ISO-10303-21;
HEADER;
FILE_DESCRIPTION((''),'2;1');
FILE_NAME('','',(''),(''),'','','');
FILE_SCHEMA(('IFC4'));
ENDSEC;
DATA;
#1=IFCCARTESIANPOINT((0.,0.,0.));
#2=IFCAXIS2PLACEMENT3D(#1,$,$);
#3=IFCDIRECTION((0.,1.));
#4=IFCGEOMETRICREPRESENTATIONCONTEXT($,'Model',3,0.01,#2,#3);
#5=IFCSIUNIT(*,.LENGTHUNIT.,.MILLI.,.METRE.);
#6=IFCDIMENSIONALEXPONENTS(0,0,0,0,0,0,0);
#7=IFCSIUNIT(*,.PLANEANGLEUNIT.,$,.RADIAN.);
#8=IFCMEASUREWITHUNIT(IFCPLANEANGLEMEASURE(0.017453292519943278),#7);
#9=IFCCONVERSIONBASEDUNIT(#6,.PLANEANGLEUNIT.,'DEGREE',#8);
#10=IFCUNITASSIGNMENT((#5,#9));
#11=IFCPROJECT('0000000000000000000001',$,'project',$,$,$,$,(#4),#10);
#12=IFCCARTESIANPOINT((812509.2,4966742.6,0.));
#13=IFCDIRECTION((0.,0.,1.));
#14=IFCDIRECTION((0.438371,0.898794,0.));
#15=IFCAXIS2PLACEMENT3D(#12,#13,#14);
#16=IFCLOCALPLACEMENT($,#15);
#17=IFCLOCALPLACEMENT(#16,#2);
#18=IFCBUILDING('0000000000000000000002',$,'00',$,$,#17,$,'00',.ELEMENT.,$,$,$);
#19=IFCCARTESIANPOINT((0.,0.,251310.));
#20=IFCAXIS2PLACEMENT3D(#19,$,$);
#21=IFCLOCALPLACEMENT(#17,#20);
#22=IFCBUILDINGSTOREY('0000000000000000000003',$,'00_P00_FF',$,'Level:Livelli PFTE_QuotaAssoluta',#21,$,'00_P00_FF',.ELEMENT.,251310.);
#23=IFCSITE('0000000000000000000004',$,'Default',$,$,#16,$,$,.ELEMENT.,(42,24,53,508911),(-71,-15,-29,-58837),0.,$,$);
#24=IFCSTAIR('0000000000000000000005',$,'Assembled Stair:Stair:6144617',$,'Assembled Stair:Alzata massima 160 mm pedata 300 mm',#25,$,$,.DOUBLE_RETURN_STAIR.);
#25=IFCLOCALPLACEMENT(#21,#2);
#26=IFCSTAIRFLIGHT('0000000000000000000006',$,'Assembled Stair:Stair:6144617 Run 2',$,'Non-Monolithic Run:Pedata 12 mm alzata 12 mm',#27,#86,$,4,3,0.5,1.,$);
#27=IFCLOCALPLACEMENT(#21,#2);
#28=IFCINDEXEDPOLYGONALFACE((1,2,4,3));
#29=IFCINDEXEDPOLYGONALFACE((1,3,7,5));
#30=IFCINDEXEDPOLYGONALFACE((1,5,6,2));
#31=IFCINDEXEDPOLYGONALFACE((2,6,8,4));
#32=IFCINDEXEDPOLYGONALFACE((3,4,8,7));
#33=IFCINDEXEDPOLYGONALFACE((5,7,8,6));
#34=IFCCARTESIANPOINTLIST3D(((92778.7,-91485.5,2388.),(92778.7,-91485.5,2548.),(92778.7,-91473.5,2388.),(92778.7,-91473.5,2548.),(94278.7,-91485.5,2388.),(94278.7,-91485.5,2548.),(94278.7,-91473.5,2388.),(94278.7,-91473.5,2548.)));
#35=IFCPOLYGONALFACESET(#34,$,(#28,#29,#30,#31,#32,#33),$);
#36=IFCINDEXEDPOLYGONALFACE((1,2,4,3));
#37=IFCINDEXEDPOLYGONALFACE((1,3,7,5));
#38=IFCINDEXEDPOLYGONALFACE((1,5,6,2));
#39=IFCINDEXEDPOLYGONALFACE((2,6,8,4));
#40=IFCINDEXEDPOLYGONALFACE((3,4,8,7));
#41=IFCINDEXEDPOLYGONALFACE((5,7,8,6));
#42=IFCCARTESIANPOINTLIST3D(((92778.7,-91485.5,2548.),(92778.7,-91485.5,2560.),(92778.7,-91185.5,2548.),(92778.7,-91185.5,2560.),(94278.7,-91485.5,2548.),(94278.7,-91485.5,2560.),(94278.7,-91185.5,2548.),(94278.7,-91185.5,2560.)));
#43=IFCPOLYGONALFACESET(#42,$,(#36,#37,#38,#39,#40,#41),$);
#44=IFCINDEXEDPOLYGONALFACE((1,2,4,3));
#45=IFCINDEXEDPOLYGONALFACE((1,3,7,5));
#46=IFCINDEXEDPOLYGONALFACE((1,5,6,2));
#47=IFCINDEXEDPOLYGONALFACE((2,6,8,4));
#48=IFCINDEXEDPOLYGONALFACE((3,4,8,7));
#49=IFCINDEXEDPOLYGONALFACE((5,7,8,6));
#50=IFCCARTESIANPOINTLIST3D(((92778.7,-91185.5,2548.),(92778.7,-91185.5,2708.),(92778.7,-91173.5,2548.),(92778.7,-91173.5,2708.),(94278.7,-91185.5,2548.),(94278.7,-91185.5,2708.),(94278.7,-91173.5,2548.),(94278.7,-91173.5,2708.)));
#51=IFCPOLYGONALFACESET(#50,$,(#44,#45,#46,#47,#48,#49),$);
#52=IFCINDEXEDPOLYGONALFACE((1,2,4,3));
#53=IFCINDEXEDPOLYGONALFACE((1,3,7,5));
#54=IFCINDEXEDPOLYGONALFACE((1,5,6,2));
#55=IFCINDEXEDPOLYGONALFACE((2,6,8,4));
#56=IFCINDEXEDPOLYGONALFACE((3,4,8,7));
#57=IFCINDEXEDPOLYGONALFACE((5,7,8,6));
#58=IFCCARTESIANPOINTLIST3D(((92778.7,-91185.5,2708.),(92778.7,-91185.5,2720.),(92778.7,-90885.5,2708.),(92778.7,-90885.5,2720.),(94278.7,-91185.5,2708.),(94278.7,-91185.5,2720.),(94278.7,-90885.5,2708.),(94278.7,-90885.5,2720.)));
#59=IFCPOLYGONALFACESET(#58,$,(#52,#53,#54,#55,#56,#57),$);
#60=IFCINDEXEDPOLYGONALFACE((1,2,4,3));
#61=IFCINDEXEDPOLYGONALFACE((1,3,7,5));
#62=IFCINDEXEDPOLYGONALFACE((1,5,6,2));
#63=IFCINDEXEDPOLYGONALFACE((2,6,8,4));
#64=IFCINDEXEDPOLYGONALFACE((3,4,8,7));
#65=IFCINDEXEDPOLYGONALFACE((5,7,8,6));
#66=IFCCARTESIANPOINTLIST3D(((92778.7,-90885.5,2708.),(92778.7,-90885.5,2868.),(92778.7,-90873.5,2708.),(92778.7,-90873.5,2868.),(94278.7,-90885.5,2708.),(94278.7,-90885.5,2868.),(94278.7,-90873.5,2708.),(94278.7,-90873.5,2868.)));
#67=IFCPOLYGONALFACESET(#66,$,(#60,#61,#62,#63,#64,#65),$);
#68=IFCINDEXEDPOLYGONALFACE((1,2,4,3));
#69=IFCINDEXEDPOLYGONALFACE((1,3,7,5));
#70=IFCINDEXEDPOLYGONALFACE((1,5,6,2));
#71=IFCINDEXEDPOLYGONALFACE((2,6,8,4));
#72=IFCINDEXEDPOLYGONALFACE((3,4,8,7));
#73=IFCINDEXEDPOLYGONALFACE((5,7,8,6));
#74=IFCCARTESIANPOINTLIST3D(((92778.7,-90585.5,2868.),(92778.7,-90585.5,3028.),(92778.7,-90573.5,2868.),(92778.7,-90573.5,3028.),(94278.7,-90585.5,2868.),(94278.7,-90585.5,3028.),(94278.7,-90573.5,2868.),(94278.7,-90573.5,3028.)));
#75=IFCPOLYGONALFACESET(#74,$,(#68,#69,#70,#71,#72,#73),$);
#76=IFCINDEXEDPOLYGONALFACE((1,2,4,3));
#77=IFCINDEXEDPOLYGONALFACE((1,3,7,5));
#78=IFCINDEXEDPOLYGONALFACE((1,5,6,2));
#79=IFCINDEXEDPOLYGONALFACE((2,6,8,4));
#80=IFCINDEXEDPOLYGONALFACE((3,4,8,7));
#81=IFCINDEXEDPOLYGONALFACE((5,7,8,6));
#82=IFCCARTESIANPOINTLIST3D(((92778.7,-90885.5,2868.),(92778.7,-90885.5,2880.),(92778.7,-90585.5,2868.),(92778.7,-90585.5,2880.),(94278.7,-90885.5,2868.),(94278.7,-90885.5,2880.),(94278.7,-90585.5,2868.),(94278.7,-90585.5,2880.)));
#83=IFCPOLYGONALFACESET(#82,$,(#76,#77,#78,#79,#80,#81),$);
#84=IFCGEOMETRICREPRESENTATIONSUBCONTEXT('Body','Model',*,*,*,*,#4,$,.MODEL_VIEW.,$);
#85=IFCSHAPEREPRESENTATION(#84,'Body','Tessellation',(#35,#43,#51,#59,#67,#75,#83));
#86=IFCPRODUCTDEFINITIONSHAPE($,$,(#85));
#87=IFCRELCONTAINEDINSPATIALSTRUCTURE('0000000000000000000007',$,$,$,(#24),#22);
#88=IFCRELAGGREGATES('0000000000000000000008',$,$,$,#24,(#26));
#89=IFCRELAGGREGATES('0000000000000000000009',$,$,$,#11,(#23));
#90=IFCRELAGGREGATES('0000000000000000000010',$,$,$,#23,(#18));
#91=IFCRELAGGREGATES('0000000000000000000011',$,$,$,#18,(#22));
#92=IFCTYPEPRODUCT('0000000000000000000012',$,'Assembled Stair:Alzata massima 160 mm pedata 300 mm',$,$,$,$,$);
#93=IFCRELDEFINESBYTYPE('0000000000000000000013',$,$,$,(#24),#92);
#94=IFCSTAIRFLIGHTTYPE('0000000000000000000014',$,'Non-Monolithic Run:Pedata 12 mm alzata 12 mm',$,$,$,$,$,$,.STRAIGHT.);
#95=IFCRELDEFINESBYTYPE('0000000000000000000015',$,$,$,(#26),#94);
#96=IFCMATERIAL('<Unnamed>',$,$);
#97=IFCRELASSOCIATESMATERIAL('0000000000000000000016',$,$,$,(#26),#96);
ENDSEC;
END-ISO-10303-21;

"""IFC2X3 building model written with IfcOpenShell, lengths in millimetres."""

from ifc_helpers import new_model, entity, si_unit, converted_unit, direction, frame, frame_2d, origin, origin_2d_with_axis, place, context, subcontext, project, spatial, rectangle, extrude, material, type_object, element, aggregate, save


model = new_model("IFC2X3")

# Units and contexts
model_context = context("Model", 3, precision=0.01, world=origin(), true_north=direction((0.0, 1.0)))
body_context = subcontext(model_context, "Body", "Model", "MODEL_VIEW")
ifc_project = project(units=[si_unit("LENGTHUNIT", "METRE", prefix="MILLI"), converted_unit("PLANEANGLEUNIT", "DEGREE", entity("IfcPlaneAngleMeasure", 0.017453292519943278), si_unit("PLANEANGLEUNIT", "RADIAN"), dimensions=[0, 0, 0, 0, 0, 0, 0])], contexts=[model_context])

# Site, building, storey
site_placement = place(None, frame((812509.2, 4966742.6, 0.0), z_axis=(0.0, 0.0, 1.0), x_axis=(0.438371, 0.898794, 0.0)))
site = spatial("IfcSite", under=ifc_project, at=site_placement, Name="Default", CompositionType="ELEMENT", RefLatitude=(42, 24, 53, 508911), RefLongitude=(-71, -15, -29, -58837), RefElevation=0.0)
building_placement = place(site_placement, origin())
building = spatial("IfcBuilding", under=site, at=building_placement, Name="00", LongName="00", CompositionType="ELEMENT")
storey_placement = place(building_placement, frame((0.0, 0.0, 251310.0)))
storey = spatial("IfcBuildingStorey", under=building, at=storey_placement, Name="00_P00_FF", ObjectType="Level:Livelli PFTE_QuotaAssoluta", LongName="00_P00_FF", CompositionType="ELEMENT", Elevation=251310.0)

# Stair
type_product_1 = type_object("IfcTypeProduct", Name="Assembled Stair:Alzata massima 160 mm pedata 300 mm")
stair_1_placement = place(storey_placement, origin())
stair_1 = element("IfcStair", 1, at=stair_1_placement, inside=storey, type_object=type_product_1, Name="Assembled Stair:Stair:6144617", ObjectType="Assembled Stair:Alzata massima 160 mm pedata 300 mm", ShapeType="DOUBLE_RETURN_STAIR")
ifc_material_1 = material(Name="<Unnamed>")

# Stair flight
stair_flight_type = type_object("IfcStairFlightType", Name="Non-Monolithic Run:Pedata 12 mm alzata 12 mm", PredefinedType="STRAIGHT")
stair_flight_1_placement = place(stair_1_placement, origin())
stair_flight_1 = element("IfcStairFlight", 2, at=stair_flight_1_placement, type_object=stair_flight_type, material=ifc_material_1, Name="Assembled Stair:Stair:6144617 Run 2", ObjectType="Non-Monolithic Run:Pedata 12 mm alzata 12 mm", NumberOfRiser=4, NumberOfTreads=3, RiserHeight=0.5, TreadLength=1.0, context=body_context, shape_type="SweptSolid", body=[
    extrude(rectangle(XDim=1500.0, YDim=12.0, at=origin_2d_with_axis()), frame((93528.7, -91479.5, 2388.0), z_axis=(0.0, 0.0, 1.0), x_axis=(-1.0, 0.0, 0.0)), (0.0, 0.0, 1.0), 160.0),
    extrude(rectangle(XDim=300.0, YDim=1500.0, at=frame_2d((0.0, 0.0), x_axis=(1.0, 0.0))), frame((93528.7, -91335.5, 2548.0), z_axis=(0.0, 0.0, 1.0), x_axis=(0.0, -1.0, 0.0)), (0.0, 0.0, 1.0), 12.0),
    extrude(rectangle(XDim=1500.0, YDim=12.0, at=frame_2d((0.0, 0.0), x_axis=(1.0, 0.0))), frame((93528.7, -91179.5, 2548.0), z_axis=(0.0, 0.0, 1.0), x_axis=(-1.0, 0.0, 0.0)), (0.0, 0.0, 1.0), 160.0),
    extrude(rectangle(XDim=300.0, YDim=1500.0, at=origin_2d_with_axis()), frame((93528.7, -91035.5, 2708.0), z_axis=(0.0, 0.0, 1.0), x_axis=(0.0, -1.0, 0.0)), (0.0, 0.0, 1.0), 12.0),
    extrude(rectangle(XDim=1500.0, YDim=12.0, at=frame_2d((0.0, 0.0), x_axis=(1.0, 0.0))), frame((93528.7, -90879.5, 2708.0), z_axis=(0.0, 0.0, 1.0), x_axis=(-1.0, 0.0, 0.0)), (0.0, 0.0, 1.0), 160.0),
    extrude(rectangle(XDim=1500.0, YDim=12.0, at=origin_2d_with_axis()), frame((93528.7, -90579.5, 2868.0), z_axis=(0.0, 0.0, 1.0), x_axis=(-1.0, 0.0, 0.0)), (0.0, 0.0, 1.0), 160.0),
    extrude(rectangle(XDim=300.0, YDim=1500.0, at=origin_2d_with_axis()), frame((93528.7, -90735.5, 2868.0), z_axis=(0.0, 0.0, 1.0), x_axis=(0.0, -1.0, 0.0)), (0.0, 0.0, 1.0), 12.0),
])
aggregate(stair_1, [stair_flight_1])

save(model, "model.ifc")
